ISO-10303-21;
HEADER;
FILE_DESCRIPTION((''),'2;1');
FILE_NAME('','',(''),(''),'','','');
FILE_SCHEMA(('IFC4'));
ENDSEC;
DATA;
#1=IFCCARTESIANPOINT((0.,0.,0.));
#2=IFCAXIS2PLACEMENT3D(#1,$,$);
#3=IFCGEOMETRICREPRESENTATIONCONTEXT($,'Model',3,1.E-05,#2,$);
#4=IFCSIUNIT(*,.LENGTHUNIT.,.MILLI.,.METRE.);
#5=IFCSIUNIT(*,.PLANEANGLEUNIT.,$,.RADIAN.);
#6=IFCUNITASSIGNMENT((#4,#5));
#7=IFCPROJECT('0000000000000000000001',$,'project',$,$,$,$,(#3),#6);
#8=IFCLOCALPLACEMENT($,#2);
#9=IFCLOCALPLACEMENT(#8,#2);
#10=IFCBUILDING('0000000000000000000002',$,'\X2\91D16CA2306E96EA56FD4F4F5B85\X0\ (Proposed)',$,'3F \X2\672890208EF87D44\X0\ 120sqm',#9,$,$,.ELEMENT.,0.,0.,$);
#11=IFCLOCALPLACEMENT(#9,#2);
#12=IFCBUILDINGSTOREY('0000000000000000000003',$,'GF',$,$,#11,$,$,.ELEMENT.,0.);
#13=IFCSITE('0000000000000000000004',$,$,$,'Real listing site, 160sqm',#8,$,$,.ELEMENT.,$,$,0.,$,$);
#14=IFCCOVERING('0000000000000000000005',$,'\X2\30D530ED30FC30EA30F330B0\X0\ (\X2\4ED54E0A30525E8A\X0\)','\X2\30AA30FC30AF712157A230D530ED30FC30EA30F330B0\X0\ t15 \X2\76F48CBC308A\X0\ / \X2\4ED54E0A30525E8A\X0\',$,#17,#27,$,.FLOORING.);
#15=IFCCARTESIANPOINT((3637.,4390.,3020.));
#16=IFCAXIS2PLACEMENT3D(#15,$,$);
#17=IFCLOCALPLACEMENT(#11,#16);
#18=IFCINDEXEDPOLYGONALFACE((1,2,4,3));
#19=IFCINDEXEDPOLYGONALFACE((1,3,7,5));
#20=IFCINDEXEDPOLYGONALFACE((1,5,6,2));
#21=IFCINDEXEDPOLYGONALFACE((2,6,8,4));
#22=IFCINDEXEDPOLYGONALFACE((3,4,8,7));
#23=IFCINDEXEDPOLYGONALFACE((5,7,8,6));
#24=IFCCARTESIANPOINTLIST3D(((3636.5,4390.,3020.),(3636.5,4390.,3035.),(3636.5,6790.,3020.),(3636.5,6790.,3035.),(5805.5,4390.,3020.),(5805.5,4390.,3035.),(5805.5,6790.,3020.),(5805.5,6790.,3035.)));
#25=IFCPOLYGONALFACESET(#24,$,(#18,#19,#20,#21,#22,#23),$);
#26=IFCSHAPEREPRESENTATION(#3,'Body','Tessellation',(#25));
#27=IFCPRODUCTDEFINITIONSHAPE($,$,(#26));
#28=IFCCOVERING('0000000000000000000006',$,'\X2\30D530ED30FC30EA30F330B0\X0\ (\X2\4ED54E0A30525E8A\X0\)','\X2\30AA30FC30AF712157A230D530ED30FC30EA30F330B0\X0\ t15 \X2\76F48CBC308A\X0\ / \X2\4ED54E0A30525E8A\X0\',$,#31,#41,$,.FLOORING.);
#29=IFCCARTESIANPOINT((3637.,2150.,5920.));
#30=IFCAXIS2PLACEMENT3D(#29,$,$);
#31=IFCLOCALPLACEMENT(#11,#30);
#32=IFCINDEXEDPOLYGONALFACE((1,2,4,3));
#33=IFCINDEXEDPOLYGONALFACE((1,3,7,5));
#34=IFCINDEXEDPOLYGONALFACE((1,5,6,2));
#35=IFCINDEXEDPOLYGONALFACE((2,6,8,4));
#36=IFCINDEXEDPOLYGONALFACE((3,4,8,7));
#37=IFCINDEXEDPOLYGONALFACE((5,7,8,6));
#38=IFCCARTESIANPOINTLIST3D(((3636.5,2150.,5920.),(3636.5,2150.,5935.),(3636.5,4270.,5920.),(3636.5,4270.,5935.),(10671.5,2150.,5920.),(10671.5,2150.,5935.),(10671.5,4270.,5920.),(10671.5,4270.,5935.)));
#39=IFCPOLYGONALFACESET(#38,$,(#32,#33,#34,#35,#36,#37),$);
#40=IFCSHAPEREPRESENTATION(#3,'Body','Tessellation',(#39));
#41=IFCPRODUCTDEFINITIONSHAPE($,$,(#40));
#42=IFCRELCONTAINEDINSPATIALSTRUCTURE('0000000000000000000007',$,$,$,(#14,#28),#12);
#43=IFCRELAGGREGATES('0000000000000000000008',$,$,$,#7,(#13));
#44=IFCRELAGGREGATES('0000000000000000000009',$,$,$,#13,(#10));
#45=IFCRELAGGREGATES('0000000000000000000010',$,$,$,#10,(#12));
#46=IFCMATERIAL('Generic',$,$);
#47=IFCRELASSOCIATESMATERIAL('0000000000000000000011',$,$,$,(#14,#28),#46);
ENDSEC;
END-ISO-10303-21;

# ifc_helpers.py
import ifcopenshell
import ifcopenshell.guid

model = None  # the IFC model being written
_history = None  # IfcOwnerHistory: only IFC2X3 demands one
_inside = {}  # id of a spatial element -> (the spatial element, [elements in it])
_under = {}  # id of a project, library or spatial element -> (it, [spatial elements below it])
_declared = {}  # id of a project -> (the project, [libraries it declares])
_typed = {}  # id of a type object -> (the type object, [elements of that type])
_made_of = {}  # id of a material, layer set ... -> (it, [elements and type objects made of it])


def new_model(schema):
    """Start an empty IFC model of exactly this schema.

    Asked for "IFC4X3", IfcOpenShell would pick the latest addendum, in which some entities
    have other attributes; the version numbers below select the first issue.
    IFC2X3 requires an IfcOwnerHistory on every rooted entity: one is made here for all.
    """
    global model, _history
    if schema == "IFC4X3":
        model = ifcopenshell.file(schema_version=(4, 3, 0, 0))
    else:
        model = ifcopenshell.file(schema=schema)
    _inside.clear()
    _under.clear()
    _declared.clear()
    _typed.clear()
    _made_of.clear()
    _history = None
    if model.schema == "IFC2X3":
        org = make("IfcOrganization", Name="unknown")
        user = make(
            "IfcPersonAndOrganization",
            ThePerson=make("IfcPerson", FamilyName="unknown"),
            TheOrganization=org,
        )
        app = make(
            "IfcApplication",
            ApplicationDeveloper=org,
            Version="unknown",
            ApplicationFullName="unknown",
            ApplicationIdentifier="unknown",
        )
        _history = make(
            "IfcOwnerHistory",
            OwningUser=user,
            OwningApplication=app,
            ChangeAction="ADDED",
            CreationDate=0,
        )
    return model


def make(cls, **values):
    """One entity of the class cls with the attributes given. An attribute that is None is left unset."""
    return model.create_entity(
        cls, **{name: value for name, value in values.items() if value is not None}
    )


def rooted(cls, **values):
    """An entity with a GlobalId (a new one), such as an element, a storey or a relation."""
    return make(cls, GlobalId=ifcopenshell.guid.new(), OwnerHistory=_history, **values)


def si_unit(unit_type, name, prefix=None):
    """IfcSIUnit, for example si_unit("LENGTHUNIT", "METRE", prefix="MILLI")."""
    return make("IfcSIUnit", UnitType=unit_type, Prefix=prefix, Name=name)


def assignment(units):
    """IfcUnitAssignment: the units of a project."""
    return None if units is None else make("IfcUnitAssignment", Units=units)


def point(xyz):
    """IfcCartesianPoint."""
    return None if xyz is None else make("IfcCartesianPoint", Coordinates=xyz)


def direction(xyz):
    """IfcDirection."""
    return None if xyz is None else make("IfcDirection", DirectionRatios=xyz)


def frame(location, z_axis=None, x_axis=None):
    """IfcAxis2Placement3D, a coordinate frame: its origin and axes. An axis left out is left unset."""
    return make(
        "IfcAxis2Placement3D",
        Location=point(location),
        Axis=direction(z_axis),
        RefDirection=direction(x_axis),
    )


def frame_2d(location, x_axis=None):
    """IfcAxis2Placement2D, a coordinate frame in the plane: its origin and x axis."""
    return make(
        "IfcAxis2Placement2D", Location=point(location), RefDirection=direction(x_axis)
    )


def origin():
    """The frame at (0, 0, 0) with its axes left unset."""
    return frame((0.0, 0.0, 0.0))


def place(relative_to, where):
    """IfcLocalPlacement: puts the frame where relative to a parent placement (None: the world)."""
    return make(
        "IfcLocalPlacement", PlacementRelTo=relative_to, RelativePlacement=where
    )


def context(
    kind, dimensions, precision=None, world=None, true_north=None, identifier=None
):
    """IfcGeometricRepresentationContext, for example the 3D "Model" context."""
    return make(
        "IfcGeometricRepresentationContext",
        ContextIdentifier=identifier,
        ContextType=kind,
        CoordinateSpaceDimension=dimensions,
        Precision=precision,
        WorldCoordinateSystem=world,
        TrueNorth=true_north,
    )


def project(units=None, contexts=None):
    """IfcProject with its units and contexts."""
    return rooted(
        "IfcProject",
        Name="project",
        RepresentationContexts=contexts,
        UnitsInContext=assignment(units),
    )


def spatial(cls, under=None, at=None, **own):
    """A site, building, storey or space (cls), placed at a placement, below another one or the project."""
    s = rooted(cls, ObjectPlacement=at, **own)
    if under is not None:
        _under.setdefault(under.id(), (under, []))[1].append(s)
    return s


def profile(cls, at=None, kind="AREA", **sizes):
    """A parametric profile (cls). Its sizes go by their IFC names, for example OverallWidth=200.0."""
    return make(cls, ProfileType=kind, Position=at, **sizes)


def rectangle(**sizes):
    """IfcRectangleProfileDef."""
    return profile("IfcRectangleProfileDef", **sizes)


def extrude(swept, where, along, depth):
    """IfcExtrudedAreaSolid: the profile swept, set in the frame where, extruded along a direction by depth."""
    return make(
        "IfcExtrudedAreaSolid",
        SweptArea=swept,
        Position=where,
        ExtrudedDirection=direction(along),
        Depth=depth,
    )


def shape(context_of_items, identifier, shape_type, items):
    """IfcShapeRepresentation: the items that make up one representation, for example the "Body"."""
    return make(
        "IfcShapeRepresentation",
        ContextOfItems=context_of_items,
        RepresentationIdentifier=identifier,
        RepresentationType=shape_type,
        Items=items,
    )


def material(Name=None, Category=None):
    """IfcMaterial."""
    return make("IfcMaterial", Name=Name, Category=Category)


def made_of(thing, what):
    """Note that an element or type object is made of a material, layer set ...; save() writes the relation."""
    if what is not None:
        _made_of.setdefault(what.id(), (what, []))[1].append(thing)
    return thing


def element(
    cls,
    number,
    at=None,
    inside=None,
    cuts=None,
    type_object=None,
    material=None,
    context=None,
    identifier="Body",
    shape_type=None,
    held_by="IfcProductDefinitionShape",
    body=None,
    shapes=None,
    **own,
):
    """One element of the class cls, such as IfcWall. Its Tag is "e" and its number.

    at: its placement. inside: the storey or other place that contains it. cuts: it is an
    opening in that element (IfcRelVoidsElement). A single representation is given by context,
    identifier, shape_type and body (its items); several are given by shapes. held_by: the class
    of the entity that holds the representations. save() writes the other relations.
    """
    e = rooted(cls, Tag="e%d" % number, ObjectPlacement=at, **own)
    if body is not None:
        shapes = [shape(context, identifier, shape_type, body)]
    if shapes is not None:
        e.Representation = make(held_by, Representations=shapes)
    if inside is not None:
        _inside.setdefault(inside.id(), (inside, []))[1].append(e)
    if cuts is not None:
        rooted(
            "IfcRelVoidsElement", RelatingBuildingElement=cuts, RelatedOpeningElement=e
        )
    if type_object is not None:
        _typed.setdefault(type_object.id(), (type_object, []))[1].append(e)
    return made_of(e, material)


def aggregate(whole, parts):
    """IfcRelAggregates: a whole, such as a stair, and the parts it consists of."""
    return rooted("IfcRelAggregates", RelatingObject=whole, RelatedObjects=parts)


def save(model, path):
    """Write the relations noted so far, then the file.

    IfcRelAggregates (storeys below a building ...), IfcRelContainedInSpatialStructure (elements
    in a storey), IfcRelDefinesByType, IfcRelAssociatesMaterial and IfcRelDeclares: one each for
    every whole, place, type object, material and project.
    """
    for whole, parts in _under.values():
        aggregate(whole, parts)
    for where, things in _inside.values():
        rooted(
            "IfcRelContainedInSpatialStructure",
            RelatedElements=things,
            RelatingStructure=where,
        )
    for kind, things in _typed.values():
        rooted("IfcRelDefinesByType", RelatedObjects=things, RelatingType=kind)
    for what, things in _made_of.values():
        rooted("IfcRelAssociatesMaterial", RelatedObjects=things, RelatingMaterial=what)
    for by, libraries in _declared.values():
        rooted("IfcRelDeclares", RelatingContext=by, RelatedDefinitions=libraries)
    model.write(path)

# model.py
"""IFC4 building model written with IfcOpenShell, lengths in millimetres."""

from ifc_helpers import new_model, si_unit, frame, frame_2d, origin, place, context, project, spatial, rectangle, extrude, material, element, save


model = new_model("IFC4")

# Units and contexts
model_context = context("Model", 3, precision=1e-05, world=origin())
ifc_project = project(units=[si_unit("LENGTHUNIT", "METRE", prefix="MILLI"), si_unit("PLANEANGLEUNIT", "RADIAN")], contexts=[model_context])

# Site, building, storey
site_placement = place(None, origin())
site = spatial("IfcSite", under=ifc_project, at=site_placement, ObjectType="Real listing site, 160sqm", CompositionType="ELEMENT", RefElevation=0.0)
building_placement = place(site_placement, origin())
building = spatial("IfcBuilding", under=site, at=building_placement, Name="金沢の雪国住宅 (Proposed)", ObjectType="3F 木造軸組 120sqm", CompositionType="ELEMENT", ElevationOfRefHeight=0.0, ElevationOfTerrain=0.0)
storey_placement = place(building_placement, origin())
storey = spatial("IfcBuildingStorey", under=building, at=storey_placement, Name="GF", CompositionType="ELEMENT", Elevation=0.0)

# Coverings
ifc_material_1 = material(Name="Generic")
covering_1_placement = place(storey_placement, frame((3637.0, 4390.0, 3020.0)))
element("IfcCovering", 1, at=covering_1_placement, inside=storey, material=ifc_material_1, Name="フローリング (仕上げ床)", Description="オーク無垢フローリング t15 直貼り / 仕上げ床", PredefinedType="FLOORING", context=model_context, shape_type="SweptSolid", body=[
    extrude(rectangle(XDim=2169.0, YDim=2400.0, at=frame_2d((1084.0, 1200.0))), frame((3637.0, 4390.0, 3020.0)), (0.0, 0.0, 1.0), 15.0),
])
covering_2_placement = place(storey_placement, frame((3637.0, 2150.0, 5920.0)))
element("IfcCovering", 2, at=covering_2_placement, inside=storey, material=ifc_material_1, Name="フローリング (仕上げ床)", Description="オーク無垢フローリング t15 直貼り / 仕上げ床", PredefinedType="FLOORING", context=model_context, shape_type="SweptSolid", body=[
    extrude(rectangle(XDim=7035.0, YDim=2120.0, at=frame_2d((3517.0, 1060.0))), frame((3637.0, 2150.0, 5920.0)), (0.0, 0.0, 1.0), 15.0),
])

save(model, "model.ifc")
